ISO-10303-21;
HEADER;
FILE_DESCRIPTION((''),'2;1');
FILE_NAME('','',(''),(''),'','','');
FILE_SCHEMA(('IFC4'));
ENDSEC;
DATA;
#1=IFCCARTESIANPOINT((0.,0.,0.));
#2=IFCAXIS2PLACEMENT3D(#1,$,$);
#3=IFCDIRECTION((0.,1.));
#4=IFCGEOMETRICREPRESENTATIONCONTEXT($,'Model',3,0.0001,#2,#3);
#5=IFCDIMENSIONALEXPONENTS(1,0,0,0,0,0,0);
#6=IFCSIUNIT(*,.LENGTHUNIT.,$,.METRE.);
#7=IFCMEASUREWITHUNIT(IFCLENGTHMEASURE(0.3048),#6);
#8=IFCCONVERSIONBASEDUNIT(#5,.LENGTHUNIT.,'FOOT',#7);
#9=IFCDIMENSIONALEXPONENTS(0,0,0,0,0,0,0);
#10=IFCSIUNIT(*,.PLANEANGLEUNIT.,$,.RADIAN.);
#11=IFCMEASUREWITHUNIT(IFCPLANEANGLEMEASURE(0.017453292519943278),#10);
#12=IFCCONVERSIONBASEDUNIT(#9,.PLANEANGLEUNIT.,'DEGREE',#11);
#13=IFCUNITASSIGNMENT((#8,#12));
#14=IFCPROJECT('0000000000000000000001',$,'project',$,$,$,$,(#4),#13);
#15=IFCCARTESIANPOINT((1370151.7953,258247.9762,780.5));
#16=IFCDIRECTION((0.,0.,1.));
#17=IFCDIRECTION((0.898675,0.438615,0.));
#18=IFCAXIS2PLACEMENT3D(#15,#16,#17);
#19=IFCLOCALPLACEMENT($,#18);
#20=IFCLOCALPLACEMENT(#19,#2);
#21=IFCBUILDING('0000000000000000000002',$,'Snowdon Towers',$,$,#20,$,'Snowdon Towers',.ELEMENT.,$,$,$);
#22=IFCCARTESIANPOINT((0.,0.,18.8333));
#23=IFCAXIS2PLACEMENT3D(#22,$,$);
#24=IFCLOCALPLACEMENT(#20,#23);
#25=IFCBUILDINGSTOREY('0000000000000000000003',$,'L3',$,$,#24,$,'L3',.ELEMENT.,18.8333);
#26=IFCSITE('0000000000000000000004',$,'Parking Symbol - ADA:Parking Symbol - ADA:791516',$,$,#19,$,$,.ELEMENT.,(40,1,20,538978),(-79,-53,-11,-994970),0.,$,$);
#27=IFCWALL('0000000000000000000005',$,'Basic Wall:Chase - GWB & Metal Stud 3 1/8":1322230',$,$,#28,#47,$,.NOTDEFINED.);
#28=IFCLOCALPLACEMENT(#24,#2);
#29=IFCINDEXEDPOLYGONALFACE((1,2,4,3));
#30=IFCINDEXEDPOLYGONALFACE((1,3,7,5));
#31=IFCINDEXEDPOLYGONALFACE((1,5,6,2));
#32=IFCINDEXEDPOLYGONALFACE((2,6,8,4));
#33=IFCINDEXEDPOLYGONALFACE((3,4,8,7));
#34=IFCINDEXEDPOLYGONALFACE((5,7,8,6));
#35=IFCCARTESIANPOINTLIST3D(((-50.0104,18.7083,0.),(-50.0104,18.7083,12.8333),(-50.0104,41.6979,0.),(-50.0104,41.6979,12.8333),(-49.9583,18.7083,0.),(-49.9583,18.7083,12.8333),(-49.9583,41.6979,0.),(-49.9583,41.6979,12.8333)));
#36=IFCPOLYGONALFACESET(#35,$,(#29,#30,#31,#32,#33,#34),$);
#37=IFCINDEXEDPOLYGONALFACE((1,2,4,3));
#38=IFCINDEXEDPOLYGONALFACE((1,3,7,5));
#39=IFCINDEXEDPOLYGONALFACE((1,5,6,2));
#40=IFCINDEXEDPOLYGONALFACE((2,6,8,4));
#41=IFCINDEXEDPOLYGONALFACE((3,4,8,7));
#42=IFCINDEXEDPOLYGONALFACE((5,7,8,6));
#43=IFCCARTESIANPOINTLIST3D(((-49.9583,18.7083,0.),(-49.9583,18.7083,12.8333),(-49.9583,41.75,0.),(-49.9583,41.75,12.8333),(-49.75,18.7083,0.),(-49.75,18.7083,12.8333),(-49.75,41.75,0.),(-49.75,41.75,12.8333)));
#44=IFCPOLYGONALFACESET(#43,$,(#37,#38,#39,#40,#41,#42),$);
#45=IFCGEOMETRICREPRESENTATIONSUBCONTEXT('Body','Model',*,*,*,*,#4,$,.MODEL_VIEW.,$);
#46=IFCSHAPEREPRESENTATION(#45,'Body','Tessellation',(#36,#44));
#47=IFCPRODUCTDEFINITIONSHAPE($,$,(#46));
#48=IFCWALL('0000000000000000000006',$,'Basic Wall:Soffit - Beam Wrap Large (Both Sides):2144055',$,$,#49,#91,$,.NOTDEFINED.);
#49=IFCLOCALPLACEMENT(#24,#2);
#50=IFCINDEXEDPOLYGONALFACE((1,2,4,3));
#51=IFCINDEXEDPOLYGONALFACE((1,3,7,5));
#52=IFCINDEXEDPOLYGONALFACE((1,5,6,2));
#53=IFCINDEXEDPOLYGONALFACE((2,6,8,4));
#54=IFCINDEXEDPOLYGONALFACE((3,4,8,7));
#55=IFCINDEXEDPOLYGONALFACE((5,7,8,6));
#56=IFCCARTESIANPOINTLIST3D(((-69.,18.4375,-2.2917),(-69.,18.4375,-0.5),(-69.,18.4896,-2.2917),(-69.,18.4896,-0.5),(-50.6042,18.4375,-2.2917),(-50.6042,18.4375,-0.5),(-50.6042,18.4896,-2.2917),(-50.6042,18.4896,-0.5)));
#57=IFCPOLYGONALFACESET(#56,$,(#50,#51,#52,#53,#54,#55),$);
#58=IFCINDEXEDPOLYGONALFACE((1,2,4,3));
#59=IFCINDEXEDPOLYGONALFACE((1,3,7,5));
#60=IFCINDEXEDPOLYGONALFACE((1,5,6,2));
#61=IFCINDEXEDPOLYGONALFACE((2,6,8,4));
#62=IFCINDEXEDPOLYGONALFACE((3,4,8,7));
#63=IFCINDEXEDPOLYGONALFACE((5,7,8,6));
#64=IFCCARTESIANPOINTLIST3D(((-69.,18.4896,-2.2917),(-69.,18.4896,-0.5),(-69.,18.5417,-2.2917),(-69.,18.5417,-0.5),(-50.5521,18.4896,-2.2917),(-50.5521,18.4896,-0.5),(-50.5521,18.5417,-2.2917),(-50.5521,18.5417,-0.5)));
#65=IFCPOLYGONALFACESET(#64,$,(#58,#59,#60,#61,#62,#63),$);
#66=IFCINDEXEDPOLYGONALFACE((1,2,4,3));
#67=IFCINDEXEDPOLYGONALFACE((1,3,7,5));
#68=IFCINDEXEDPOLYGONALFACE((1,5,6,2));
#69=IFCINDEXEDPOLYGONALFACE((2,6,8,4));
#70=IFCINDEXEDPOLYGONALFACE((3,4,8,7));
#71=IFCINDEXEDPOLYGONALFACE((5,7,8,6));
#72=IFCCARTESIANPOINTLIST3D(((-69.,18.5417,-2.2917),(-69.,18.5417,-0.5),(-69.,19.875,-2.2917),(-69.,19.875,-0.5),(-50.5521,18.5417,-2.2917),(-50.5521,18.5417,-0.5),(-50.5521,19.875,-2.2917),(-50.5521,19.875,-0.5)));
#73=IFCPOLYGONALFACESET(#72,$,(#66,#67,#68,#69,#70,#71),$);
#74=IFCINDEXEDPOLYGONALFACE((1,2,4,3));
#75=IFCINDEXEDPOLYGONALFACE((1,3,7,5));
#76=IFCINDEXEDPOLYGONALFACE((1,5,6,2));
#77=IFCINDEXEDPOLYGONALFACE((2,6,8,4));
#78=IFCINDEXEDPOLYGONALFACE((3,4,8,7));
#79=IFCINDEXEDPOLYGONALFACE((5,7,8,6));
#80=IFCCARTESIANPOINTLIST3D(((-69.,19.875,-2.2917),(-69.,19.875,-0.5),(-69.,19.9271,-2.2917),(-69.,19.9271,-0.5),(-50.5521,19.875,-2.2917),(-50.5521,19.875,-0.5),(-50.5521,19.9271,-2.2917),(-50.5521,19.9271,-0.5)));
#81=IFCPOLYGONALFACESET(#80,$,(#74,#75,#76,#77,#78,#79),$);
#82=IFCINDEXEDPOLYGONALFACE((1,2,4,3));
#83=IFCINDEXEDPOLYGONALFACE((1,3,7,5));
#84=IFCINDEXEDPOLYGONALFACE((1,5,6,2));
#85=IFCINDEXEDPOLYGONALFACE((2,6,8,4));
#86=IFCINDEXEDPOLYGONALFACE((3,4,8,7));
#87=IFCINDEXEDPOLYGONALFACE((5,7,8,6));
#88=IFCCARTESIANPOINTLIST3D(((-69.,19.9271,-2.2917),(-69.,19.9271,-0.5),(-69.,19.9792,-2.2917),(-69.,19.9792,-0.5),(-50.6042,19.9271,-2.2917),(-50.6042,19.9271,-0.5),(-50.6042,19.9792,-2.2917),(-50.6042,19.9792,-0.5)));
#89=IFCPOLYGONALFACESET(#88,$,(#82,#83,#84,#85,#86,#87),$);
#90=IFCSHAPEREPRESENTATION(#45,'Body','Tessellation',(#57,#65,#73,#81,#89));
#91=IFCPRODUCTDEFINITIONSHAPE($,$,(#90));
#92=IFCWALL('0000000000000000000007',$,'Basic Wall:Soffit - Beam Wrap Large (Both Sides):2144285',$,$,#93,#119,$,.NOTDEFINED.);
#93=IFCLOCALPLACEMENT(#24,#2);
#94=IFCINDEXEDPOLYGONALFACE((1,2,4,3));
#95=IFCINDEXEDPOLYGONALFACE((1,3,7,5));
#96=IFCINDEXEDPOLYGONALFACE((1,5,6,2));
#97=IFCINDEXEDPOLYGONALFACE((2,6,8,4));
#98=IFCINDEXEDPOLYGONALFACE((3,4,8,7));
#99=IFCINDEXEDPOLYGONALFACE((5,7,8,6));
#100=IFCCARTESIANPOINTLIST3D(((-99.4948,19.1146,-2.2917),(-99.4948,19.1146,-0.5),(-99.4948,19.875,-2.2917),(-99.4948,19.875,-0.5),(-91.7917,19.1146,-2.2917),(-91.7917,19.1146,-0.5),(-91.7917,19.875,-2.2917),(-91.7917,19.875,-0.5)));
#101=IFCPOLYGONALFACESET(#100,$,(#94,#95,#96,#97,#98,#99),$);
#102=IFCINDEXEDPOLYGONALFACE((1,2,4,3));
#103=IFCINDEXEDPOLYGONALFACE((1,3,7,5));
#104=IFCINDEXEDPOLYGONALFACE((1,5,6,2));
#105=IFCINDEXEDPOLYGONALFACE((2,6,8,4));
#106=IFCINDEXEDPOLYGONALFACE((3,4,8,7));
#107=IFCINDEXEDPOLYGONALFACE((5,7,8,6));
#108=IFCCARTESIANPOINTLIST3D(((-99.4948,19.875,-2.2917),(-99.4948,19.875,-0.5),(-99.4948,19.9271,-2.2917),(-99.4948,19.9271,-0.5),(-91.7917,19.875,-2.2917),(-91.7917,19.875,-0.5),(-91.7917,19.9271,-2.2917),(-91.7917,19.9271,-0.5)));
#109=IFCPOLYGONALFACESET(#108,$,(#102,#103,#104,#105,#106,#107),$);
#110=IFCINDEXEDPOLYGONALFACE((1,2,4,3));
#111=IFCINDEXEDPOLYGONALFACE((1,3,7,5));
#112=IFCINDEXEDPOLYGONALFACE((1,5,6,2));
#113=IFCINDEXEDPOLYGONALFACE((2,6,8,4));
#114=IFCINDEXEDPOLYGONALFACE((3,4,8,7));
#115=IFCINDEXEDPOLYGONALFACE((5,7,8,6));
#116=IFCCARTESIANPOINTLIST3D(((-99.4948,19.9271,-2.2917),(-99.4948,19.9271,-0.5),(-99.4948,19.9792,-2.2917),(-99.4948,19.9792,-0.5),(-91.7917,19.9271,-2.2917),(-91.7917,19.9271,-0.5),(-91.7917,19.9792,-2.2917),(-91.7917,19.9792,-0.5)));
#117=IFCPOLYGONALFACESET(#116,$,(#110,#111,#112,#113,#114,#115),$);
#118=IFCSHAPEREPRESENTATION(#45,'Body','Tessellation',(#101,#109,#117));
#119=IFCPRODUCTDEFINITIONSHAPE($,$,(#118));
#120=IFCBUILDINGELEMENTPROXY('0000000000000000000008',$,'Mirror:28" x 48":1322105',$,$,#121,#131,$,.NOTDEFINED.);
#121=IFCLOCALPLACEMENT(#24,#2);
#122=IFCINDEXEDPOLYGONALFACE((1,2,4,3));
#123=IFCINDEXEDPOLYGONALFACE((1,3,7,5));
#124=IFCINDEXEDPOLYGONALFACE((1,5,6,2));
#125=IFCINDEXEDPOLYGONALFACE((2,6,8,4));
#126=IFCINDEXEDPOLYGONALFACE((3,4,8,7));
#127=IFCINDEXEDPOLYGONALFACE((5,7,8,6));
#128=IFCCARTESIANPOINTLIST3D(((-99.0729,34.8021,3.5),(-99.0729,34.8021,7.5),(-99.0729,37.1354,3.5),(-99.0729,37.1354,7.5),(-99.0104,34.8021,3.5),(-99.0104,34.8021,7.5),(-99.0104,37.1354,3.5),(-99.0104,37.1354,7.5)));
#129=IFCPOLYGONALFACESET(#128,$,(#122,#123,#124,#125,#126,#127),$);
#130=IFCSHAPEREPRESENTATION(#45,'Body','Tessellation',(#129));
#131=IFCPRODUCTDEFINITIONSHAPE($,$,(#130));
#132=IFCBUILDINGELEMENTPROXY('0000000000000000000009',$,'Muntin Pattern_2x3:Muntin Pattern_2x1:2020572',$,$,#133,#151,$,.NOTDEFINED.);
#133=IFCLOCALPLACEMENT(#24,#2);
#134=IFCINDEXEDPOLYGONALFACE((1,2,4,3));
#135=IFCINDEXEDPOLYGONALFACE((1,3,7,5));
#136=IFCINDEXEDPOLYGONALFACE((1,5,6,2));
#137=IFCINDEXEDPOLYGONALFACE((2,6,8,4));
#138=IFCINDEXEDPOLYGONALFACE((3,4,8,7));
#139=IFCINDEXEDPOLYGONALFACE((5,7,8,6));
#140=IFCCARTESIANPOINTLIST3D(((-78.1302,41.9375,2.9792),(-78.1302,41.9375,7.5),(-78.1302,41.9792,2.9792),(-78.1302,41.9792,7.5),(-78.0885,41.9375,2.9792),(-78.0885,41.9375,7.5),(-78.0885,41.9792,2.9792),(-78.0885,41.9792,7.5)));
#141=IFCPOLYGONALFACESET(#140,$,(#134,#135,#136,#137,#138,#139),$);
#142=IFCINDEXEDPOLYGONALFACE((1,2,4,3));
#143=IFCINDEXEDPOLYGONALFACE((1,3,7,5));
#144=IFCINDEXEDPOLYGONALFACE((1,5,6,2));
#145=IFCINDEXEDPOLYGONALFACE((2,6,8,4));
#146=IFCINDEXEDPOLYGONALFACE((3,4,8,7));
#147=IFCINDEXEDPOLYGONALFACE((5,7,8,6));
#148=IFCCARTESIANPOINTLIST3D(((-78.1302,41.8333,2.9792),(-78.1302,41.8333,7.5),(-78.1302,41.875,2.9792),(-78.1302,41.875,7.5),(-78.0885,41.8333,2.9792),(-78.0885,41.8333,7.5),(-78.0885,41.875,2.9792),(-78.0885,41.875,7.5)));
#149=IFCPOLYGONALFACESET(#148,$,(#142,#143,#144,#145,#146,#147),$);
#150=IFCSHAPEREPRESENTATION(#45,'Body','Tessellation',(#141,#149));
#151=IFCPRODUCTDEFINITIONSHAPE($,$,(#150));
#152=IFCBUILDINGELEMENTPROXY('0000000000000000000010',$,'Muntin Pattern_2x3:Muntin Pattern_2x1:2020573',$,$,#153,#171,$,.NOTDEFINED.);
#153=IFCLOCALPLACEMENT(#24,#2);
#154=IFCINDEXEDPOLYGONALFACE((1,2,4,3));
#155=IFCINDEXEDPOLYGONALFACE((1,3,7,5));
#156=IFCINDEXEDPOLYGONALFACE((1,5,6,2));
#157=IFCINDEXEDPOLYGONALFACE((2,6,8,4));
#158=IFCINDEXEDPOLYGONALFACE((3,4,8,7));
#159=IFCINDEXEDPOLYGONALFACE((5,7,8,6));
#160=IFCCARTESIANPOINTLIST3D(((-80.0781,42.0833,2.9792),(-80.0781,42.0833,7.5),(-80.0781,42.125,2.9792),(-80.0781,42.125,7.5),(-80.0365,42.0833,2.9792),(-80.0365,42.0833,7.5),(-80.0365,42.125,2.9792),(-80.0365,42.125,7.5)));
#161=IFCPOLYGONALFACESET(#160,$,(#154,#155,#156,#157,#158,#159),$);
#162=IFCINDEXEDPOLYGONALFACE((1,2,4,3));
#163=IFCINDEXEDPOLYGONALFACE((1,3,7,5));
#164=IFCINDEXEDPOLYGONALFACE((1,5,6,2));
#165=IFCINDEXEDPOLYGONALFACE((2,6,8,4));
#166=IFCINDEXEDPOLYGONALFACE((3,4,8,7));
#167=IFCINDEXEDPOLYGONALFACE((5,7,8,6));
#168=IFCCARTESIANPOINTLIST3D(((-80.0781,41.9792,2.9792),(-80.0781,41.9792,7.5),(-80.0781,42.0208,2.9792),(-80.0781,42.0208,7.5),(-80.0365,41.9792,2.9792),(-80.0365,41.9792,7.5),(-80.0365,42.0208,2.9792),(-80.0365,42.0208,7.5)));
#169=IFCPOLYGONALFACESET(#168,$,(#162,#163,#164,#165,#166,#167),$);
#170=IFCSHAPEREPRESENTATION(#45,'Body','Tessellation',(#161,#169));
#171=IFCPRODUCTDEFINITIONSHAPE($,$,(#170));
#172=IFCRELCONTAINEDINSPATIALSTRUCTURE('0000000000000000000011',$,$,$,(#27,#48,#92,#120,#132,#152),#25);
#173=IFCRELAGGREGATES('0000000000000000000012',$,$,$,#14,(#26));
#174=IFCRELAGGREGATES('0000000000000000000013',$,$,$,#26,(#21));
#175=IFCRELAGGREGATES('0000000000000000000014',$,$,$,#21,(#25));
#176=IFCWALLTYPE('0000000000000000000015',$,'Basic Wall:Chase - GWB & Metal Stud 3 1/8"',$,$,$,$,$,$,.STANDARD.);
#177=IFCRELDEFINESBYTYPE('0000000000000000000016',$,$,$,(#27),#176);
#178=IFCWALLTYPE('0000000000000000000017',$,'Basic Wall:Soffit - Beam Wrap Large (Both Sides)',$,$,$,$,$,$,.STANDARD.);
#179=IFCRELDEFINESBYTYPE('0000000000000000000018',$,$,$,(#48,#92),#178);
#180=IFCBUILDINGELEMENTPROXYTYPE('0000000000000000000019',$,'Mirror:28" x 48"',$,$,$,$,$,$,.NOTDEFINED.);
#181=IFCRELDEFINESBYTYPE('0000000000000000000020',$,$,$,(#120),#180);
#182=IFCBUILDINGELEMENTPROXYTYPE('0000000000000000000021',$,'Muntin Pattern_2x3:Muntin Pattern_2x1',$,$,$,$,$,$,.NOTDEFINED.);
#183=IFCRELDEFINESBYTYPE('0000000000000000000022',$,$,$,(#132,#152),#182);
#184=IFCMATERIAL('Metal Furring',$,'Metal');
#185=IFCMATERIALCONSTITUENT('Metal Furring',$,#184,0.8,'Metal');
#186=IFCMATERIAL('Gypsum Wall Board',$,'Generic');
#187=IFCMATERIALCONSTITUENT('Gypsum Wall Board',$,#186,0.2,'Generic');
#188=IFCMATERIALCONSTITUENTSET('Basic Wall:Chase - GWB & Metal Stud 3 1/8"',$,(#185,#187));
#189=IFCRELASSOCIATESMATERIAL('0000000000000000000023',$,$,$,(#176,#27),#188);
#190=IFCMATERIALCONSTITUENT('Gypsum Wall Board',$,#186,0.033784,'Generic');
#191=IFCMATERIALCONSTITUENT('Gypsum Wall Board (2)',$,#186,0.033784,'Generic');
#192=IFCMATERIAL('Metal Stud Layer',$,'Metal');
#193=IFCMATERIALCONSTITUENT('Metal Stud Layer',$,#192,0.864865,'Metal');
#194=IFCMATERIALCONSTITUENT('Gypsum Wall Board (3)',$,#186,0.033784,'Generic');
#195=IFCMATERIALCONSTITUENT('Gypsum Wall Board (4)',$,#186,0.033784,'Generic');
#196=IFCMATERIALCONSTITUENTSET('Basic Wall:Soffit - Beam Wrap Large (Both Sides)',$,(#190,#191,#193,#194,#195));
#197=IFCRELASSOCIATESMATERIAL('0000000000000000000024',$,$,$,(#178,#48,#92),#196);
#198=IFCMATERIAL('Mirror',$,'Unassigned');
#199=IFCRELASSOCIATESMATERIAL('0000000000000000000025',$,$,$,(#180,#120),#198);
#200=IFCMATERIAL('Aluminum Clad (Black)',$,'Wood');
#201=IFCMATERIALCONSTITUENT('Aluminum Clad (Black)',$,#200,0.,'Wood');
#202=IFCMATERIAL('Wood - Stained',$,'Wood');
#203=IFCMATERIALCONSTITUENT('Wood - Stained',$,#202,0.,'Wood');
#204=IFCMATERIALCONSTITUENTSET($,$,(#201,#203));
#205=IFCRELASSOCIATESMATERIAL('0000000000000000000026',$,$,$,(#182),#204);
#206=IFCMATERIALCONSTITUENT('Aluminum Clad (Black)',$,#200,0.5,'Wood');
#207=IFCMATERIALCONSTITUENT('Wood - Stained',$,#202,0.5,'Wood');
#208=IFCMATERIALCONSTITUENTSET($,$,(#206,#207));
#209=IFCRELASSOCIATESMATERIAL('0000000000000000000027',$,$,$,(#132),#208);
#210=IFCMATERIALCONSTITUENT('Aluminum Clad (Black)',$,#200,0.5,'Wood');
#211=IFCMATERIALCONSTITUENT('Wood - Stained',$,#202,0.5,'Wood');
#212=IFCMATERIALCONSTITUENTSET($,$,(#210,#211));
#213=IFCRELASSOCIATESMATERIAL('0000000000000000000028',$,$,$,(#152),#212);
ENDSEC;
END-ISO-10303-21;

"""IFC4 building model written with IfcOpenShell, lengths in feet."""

from ifc_helpers import new_model, entity, si_unit, converted_unit, direction, frame, origin, place, context, subcontext, project, spatial, indexed_curve, outline, extrude, source, transform, mapped, material, constituent, constituent_set, type_object, type_shapes, element, save


model = new_model("IFC4")

# Units and contexts
model_context = context("Model", 3, precision=0.0001, world=origin(), true_north=direction((0.0, 1.0)))
body_context = subcontext(model_context, "Body", "Model", "MODEL_VIEW")
ifc_project = project(units=[converted_unit("LENGTHUNIT", "FOOT", entity("IfcLengthMeasure", 0.3048), si_unit("LENGTHUNIT", "METRE"), dimensions=[1, 0, 0, 0, 0, 0, 0]), converted_unit("PLANEANGLEUNIT", "DEGREE", entity("IfcPlaneAngleMeasure", 0.017453292519943278), si_unit("PLANEANGLEUNIT", "RADIAN"), dimensions=[0, 0, 0, 0, 0, 0, 0])], contexts=[model_context])

# Site, building, storey
site_placement = place(None, frame((1370151.7953, 258247.9762, 780.5), z_axis=(0.0, 0.0, 1.0), x_axis=(0.898675, 0.438615, 0.0)))
site = spatial("IfcSite", under=ifc_project, at=site_placement, Name="Parking Symbol - ADA:Parking Symbol - ADA:791516", CompositionType="ELEMENT", RefLatitude=(40, 1, 20, 538978), RefLongitude=(-79, -53, -11, -994970), RefElevation=0.0)
building_placement = place(site_placement, origin())
building = spatial("IfcBuilding", under=site, at=building_placement, Name="Snowdon Towers", LongName="Snowdon Towers", CompositionType="ELEMENT")
storey_placement = place(building_placement, frame((0.0, 0.0, 18.8333)))
storey = spatial("IfcBuildingStorey", under=building, at=storey_placement, Name="L3", LongName="L3", CompositionType="ELEMENT", Elevation=18.8333)

# Shared definitions
ifc_material_1 = material(Name="Aluminum Clad (Black)", Category="Wood")

# Shared definitions
ifc_material_2 = material(Name="Metal Furring", Category="Metal")
ifc_material_3 = material(Name="Gypsum Wall Board", Category="Generic")

# Shared definitions
ifc_material_4 = material(Name="Metal Stud Layer", Category="Metal")

# Shared definitions
ifc_constituent_1 = constituent(ifc_material_2, Name="Metal Furring", Category="Metal", fraction=0.8)
ifc_constituent_2 = constituent(ifc_material_3, Name="Gypsum Wall Board", Category="Generic", fraction=0.2)
ifc_constituent_set_1 = constituent_set(constituents=[ifc_constituent_1, ifc_constituent_2], Name="Basic Wall:Chase - GWB & Metal Stud 3 1/8\"")
wall_type_1 = type_object("IfcWallType", Name="Basic Wall:Chase - GWB & Metal Stud 3 1/8\"", PredefinedType="STANDARD", material=ifc_constituent_set_1)

# Walls
wall_1_placement = place(storey_placement, frame((-49.8802, 41.6979, 0.0), z_axis=(0.0, 0.0, 1.0), x_axis=(0.0, -1.0, 0.0)))
element("IfcWall", 1, at=wall_1_placement, inside=storey, type_object=wall_type_1, material=ifc_constituent_set_1, Name="Basic Wall:Chase - GWB & Metal Stud 3 1/8\":1322230", PredefinedType="NOTDEFINED", context=body_context, shape_type="SweptSolid", body=[
    extrude(outline(indexed_curve([(-0.026, -11.4948), (0.026, -11.4948), (0.026, 11.4948), (-0.026, 11.4948), (-0.026, -11.4948)], self_intersect=False)), frame((11.4948, -0.1042, 0.0), z_axis=(0.0, 0.0, 1.0), x_axis=(0.0, 1.0, 0.0)), (0.0, 0.0, 1.0), 12.8333),
    extrude(outline(indexed_curve([(-0.1042, -11.5208), (0.1042, -11.5208), (0.1042, 11.5208), (-0.1042, 11.5208), (-0.1042, -11.5208)], self_intersect=False)), frame((11.4688, 0.026, 0.0), z_axis=(0.0, 0.0, 1.0), x_axis=(0.0, 1.0, 0.0)), (0.0, 0.0, 1.0), 12.8333),
])
ifc_constituent_3 = constituent(ifc_material_3, Name="Gypsum Wall Board", Category="Generic", fraction=0.033784)
ifc_constituent_4 = constituent(ifc_material_3, Name="Gypsum Wall Board (2)", Category="Generic", fraction=0.033784)
ifc_constituent_5 = constituent(ifc_material_4, Name="Metal Stud Layer", Category="Metal", fraction=0.864865)
ifc_constituent_6 = constituent(ifc_material_3, Name="Gypsum Wall Board (3)", Category="Generic", fraction=0.033784)
ifc_constituent_7 = constituent(ifc_material_3, Name="Gypsum Wall Board (4)", Category="Generic", fraction=0.033784)
ifc_constituent_set_2 = constituent_set(constituents=[ifc_constituent_3, ifc_constituent_4, ifc_constituent_5, ifc_constituent_6, ifc_constituent_7], Name="Basic Wall:Soffit - Beam Wrap Large (Both Sides)")
wall_type_2 = type_object("IfcWallType", Name="Basic Wall:Soffit - Beam Wrap Large (Both Sides)", PredefinedType="STANDARD", material=ifc_constituent_set_2)
wall_2_placement = place(storey_placement, frame((-69.0, 19.2083, -2.2917)))
element("IfcWall", 2, at=wall_2_placement, inside=storey, type_object=wall_type_2, material=ifc_constituent_set_2, Name="Basic Wall:Soffit - Beam Wrap Large (Both Sides):2144055", PredefinedType="NOTDEFINED", context=body_context, shape_type="SweptSolid", body=[
    extrude(outline(indexed_curve([(-0.026, -9.1979), (0.026, -9.1979), (0.026, 9.1979), (-0.026, 9.1979), (-0.026, -9.1979)], self_intersect=False)), frame((9.1979, -0.7448, 0.0), z_axis=(0.0, 0.0, 1.0), x_axis=(0.0, 1.0, 0.0)), (0.0, 0.0, 1.0), 1.7917),
    extrude(outline(indexed_curve([(-9.224, -0.026), (9.224, -0.026), (9.224, 0.026), (-9.224, 0.026), (-9.224, -0.026)], self_intersect=False)), frame((9.224, -0.6927, 0.0)), (0.0, 0.0, 1.0), 1.7917),
    extrude(outline(indexed_curve([(-9.224, -0.6667), (9.224, -0.6667), (9.224, 0.6667), (-9.224, 0.6667), (-9.224, -0.6667)], self_intersect=False)), frame((9.224, 0.0, 0.0)), (0.0, 0.0, 1.0), 1.7917),
    extrude(outline(indexed_curve([(-9.224, -0.026), (9.224, -0.026), (9.224, 0.026), (-9.224, 0.026), (-9.224, -0.026)], self_intersect=False)), frame((9.224, 0.6927, 0.0)), (0.0, 0.0, 1.0), 1.7917),
    extrude(outline(indexed_curve([(-0.026, -9.1979), (0.026, -9.1979), (0.026, 9.1979), (-0.026, 9.1979), (-0.026, -9.1979)], self_intersect=False)), frame((9.1979, 0.7448, 0.0), z_axis=(0.0, 0.0, 1.0), x_axis=(0.0, -1.0, 0.0)), (0.0, 0.0, 1.0), 1.7917),
])
wall_3_placement = place(storey_placement, frame((-99.4948, 19.2083, -2.2917)))
element("IfcWall", 3, at=wall_3_placement, inside=storey, type_object=wall_type_2, material=ifc_constituent_set_2, Name="Basic Wall:Soffit - Beam Wrap Large (Both Sides):2144285", PredefinedType="NOTDEFINED", context=body_context, shape_type="SweptSolid", body=[
    extrude(outline(indexed_curve([(-0.3802, -3.8516), (0.3802, -3.8516), (0.3802, 3.8516), (-0.3802, 3.8516), (-0.3802, -3.8516)], self_intersect=False)), frame((3.8516, 0.2865, 0.0), z_axis=(0.0, 0.0, 1.0), x_axis=(0.0, 1.0, 0.0)), (0.0, 0.0, 1.0), 1.7917),
    extrude(outline(indexed_curve([(-3.8516, -0.026), (3.8516, -0.026), (3.8516, 0.026), (-3.8516, 0.026), (-3.8516, -0.026)], self_intersect=False)), frame((3.8516, 0.6927, 0.0)), (0.0, 0.0, 1.0), 1.7917),
    extrude(outline(indexed_curve([(-0.026, -3.8516), (0.026, -3.8516), (0.026, 3.8516), (-0.026, 3.8516), (-0.026, -3.8516)], self_intersect=False)), frame((3.8516, 0.7448, 0.0), z_axis=(0.0, 0.0, 1.0), x_axis=(0.0, -1.0, 0.0)), (0.0, 0.0, 1.0), 1.7917),
])

# Building element proxies
ifc_material_5 = material(Name="Mirror", Category="Unassigned")
building_element_proxy_type_1 = type_object("IfcBuildingElementProxyType", Name="Mirror:28\" x 48\"", PredefinedType="NOTDEFINED", material=ifc_material_5)
shared_shape_1 = source(origin(), body_context, "Body", "SweptSolid", [
    extrude(outline(indexed_curve([(-1.1667, -0.0312), (1.1667, -0.0312), (1.1667, 0.0312), (-1.1667, 0.0312), (-1.1667, -0.0312)], self_intersect=False)), frame((0.0803, -0.3073, 3.5)), (0.0, 0.0, 1.0), 4.0),
])
type_shapes(building_element_proxy_type_1, [shared_shape_1])
proxy_1_placement = place(storey_placement, frame((-99.349, 35.8885, 0.0), z_axis=(0.0, 0.0, 1.0), x_axis=(0.0, 1.0, 0.0)))
element("IfcBuildingElementProxy", 4, at=proxy_1_placement, inside=storey, type_object=building_element_proxy_type_1, material=ifc_material_5, Name="Mirror:28\" x 48\":1322105", PredefinedType="NOTDEFINED", context=body_context, shape_type="MappedRepresentation", body=[
    mapped(shared_shape_1, transform((0.0, 0.0, 0.0), scale=1.0)),
])
ifc_constituent_8 = constituent(ifc_material_1, Name="Aluminum Clad (Black)", Category="Wood", fraction=0.5)
ifc_material_6 = material(Name="Wood - Stained", Category="Wood")
ifc_constituent_9 = constituent(ifc_material_6, Name="Wood - Stained", Category="Wood", fraction=0.5)
ifc_constituent_set_3 = constituent_set(constituents=[ifc_constituent_8, ifc_constituent_9])
ifc_constituent_10 = constituent(ifc_material_1, Name="Aluminum Clad (Black)", Category="Wood", fraction=0.0)
ifc_constituent_11 = constituent(ifc_material_6, Name="Wood - Stained", Category="Wood", fraction=0.0)
ifc_constituent_set_4 = constituent_set(constituents=[ifc_constituent_10, ifc_constituent_11])
building_element_proxy_type_2 = type_object("IfcBuildingElementProxyType", Name="Muntin Pattern_2x3:Muntin Pattern_2x1", PredefinedType="NOTDEFINED", material=ifc_constituent_set_4)
shared_shape_2 = source(origin(), body_context, "Body", "SweptSolid", [
    extrude(outline(indexed_curve([(-0.0208, -0.0208), (0.0208, -0.0208), (0.0208, 0.0208), (-0.0208, 0.0208), (-0.0208, -0.0208)], self_intersect=False)), frame((0.0, 0.0521, 0.0), z_axis=(0.0, 0.0, 1.0), x_axis=(0.0, -1.0, 0.0)), (0.0, 0.0, 1.0), 4.5208),
    extrude(outline(indexed_curve([(-0.0208, -0.0208), (0.0208, -0.0208), (0.0208, 0.0208), (-0.0208, 0.0208), (-0.0208, -0.0208)], self_intersect=False)), frame((0.0, -0.0521, 0.0), z_axis=(0.0, 0.0, 1.0), x_axis=(0.0, -1.0, 0.0)), (0.0, 0.0, 1.0), 4.5208),
])
type_shapes(building_element_proxy_type_2, [shared_shape_2])
proxy_2_placement = place(storey_placement, frame((-78.1094, 41.9063, 2.9792)))
element("IfcBuildingElementProxy", 5, at=proxy_2_placement, inside=storey, type_object=building_element_proxy_type_2, material=ifc_constituent_set_3, Name="Muntin Pattern_2x3:Muntin Pattern_2x1:2020572", PredefinedType="NOTDEFINED", context=body_context, shape_type="MappedRepresentation", body=[
    mapped(shared_shape_2, transform((0.0, 0.0, 0.0), scale=1.0)),
])
ifc_constituent_12 = constituent(ifc_material_1, Name="Aluminum Clad (Black)", Category="Wood", fraction=0.5)
ifc_constituent_13 = constituent(ifc_material_6, Name="Wood - Stained", Category="Wood", fraction=0.5)
ifc_constituent_set_5 = constituent_set(constituents=[ifc_constituent_12, ifc_constituent_13])
proxy_3_placement = place(storey_placement, frame((-80.0573, 42.0521, 2.9792)))
element("IfcBuildingElementProxy", 6, at=proxy_3_placement, inside=storey, type_object=building_element_proxy_type_2, material=ifc_constituent_set_5, Name="Muntin Pattern_2x3:Muntin Pattern_2x1:2020573", PredefinedType="NOTDEFINED", context=body_context, shape_type="MappedRepresentation", body=[
    mapped(shared_shape_2, transform((0.0, 0.0, 0.0), scale=1.0)),
])

save(model, "model.ifc")
